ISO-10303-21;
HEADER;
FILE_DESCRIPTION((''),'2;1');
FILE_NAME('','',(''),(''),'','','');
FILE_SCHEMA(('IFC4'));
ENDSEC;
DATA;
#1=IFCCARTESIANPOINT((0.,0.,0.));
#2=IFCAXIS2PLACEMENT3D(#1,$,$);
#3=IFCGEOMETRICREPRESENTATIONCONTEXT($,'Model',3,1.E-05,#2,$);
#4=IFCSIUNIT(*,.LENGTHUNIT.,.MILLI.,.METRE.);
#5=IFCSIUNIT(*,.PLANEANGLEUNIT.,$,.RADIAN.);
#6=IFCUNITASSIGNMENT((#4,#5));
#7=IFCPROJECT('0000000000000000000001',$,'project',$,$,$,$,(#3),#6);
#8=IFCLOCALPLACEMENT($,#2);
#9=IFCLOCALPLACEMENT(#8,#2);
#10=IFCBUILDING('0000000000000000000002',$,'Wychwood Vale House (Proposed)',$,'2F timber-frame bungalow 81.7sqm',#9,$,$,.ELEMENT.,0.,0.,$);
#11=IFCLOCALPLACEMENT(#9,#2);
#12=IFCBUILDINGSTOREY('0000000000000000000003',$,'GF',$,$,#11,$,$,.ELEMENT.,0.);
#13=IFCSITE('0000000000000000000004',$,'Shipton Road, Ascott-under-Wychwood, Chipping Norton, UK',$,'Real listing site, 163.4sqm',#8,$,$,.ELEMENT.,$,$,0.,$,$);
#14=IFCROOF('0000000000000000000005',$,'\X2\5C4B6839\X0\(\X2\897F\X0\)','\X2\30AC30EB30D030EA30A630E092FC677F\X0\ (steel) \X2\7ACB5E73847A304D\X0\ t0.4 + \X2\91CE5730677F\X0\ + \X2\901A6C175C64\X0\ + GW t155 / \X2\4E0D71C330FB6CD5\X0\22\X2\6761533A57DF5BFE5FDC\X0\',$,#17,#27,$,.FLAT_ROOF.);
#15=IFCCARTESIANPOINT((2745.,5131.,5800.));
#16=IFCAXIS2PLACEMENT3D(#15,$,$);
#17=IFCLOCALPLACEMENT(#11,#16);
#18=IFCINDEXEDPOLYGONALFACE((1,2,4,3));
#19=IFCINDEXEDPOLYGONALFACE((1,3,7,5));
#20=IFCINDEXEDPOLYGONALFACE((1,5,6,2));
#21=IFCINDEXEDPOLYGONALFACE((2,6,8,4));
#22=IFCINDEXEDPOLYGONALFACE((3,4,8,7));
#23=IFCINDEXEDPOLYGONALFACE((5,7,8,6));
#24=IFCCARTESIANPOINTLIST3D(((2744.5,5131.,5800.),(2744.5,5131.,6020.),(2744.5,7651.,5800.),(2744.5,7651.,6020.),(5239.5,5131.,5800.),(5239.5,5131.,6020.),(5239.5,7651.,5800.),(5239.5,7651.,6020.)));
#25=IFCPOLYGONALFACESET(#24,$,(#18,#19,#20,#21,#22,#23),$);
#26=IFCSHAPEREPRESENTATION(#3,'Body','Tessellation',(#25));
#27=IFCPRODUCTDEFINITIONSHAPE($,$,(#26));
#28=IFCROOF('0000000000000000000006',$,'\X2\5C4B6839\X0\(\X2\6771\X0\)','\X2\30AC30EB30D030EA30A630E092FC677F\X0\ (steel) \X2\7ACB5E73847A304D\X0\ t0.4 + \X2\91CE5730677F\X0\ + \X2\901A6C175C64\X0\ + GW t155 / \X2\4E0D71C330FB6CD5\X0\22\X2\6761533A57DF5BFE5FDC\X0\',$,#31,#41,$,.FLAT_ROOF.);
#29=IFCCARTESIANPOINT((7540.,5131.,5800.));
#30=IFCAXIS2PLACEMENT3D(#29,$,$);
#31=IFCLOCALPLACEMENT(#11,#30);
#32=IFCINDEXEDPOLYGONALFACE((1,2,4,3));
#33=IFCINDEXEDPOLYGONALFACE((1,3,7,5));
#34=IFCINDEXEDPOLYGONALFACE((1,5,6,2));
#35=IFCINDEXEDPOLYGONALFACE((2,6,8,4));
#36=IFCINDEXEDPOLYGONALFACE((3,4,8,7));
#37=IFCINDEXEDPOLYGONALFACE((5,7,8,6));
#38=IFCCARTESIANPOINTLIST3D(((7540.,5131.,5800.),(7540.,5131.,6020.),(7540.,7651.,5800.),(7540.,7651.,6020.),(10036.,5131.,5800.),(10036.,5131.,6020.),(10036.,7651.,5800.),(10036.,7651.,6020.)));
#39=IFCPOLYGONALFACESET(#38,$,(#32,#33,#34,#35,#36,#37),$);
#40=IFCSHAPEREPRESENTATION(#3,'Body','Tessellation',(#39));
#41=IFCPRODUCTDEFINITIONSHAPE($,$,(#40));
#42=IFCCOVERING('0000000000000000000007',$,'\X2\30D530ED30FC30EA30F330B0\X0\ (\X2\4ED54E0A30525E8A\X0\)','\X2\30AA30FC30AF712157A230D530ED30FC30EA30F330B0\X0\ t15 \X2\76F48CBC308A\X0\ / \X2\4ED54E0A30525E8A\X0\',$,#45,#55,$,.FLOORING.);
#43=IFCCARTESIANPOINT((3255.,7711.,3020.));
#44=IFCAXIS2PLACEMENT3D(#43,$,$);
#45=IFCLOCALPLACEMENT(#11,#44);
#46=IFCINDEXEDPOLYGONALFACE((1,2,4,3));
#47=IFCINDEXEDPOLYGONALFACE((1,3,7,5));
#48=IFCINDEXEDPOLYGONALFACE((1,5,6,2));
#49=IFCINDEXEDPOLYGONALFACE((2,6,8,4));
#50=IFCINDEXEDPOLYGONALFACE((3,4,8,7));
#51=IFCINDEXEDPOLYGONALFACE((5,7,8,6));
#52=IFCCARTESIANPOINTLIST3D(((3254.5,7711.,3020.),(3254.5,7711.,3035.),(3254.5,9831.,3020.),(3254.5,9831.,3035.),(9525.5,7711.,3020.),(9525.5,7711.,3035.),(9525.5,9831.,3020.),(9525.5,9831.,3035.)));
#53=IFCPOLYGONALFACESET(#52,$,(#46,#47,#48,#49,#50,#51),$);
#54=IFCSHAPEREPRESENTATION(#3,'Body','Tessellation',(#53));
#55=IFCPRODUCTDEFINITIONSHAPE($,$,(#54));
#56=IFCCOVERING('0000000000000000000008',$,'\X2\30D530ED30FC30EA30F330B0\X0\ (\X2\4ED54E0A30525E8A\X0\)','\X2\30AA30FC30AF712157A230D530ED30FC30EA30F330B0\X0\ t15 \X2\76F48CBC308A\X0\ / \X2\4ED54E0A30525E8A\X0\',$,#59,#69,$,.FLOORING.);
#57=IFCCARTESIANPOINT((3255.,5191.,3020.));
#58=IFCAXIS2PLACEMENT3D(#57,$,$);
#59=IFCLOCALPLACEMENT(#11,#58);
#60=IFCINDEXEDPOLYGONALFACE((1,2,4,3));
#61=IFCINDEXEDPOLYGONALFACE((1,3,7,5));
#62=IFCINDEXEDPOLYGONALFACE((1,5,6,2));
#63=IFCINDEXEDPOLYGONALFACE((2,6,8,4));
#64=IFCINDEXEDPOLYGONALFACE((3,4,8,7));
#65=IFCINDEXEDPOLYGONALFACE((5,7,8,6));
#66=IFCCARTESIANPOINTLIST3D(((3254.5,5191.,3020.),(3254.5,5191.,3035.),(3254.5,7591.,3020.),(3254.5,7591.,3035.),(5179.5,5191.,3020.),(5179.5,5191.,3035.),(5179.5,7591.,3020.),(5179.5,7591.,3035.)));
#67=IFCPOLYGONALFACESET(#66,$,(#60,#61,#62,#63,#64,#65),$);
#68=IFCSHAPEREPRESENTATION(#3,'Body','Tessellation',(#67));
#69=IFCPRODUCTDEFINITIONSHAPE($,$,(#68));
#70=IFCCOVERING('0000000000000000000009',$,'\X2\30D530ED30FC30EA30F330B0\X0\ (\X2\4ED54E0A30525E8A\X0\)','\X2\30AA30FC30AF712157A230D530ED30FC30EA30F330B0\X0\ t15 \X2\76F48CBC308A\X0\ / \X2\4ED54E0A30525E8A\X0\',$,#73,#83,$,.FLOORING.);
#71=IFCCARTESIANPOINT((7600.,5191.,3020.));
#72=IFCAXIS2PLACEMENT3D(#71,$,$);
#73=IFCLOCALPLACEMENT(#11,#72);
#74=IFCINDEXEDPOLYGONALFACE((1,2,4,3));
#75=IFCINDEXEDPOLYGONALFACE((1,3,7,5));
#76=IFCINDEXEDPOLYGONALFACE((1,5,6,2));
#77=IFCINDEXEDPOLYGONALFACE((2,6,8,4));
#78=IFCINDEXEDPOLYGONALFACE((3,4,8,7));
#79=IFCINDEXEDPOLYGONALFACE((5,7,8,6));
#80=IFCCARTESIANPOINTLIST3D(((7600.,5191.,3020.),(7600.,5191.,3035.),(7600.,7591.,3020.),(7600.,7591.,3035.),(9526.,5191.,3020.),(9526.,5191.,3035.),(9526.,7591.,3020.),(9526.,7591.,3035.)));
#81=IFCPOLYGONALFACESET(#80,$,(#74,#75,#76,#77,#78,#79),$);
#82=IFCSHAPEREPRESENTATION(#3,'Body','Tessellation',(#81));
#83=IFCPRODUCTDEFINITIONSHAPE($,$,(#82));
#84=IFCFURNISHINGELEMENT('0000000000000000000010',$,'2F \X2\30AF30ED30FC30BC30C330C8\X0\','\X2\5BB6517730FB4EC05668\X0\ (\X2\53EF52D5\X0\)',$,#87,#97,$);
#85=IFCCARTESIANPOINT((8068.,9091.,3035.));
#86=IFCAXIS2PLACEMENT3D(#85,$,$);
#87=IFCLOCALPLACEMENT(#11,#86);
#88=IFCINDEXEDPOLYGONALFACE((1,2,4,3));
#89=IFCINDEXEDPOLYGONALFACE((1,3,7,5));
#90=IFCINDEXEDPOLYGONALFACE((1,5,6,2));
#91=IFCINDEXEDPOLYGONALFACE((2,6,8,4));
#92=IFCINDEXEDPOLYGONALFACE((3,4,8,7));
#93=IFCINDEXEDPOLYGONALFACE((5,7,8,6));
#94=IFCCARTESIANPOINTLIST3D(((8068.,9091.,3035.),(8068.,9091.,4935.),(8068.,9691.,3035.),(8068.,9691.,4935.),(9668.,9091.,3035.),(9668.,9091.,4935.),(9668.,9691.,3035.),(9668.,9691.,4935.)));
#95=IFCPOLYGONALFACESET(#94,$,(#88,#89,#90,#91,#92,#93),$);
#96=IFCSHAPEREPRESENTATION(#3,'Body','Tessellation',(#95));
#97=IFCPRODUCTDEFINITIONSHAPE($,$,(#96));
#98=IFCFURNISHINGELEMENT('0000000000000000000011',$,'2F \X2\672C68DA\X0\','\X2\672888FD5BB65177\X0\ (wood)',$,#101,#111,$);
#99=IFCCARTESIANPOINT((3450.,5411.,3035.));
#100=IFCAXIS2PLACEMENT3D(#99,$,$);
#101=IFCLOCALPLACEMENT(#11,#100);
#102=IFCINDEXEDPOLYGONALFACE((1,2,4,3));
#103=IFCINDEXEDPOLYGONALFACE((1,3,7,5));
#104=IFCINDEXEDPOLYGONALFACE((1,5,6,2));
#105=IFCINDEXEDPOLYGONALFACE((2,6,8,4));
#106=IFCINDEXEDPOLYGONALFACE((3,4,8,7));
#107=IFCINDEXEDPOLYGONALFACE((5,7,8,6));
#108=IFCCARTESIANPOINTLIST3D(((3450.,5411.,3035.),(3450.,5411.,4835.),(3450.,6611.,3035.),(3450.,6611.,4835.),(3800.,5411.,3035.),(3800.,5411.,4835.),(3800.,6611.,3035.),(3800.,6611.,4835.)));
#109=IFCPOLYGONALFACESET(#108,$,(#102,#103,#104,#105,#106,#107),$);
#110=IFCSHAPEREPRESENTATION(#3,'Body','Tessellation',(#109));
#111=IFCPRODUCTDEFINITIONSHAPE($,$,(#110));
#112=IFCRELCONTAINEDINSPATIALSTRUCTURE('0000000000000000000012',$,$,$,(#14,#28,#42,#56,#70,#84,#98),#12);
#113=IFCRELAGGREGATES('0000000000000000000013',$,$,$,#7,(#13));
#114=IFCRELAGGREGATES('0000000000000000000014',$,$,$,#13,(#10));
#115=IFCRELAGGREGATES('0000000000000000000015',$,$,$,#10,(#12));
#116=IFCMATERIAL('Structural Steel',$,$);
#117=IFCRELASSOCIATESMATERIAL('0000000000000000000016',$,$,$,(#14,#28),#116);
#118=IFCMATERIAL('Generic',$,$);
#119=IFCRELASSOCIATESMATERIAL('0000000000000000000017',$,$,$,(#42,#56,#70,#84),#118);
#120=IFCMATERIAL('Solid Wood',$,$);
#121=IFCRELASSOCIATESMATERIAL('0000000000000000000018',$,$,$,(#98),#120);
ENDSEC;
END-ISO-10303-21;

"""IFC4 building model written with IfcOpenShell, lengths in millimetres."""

from ifc_helpers import new_model, si_unit, frame, frame_2d, origin, place, context, project, spatial, rectangle, extrude, material, element, save


model = new_model("IFC4")

# Units and contexts
model_context = context("Model", 3, precision=1e-05, world=origin())
ifc_project = project(units=[si_unit("LENGTHUNIT", "METRE", prefix="MILLI"), si_unit("PLANEANGLEUNIT", "RADIAN")], contexts=[model_context])

# Site, building, storey
site_placement = place(None, origin())
site = spatial("IfcSite", under=ifc_project, at=site_placement, Name="Shipton Road, Ascott-under-Wychwood, Chipping Norton, UK", ObjectType="Real listing site, 163.4sqm", CompositionType="ELEMENT", RefElevation=0.0)
building_placement = place(site_placement, origin())
building = spatial("IfcBuilding", under=site, at=building_placement, Name="Wychwood Vale House (Proposed)", ObjectType="2F timber-frame bungalow 81.7sqm", CompositionType="ELEMENT", ElevationOfRefHeight=0.0, ElevationOfTerrain=0.0)
storey_placement = place(building_placement, origin())
storey = spatial("IfcBuildingStorey", under=building, at=storey_placement, Name="GF", CompositionType="ELEMENT", Elevation=0.0)

# Shared definitions
ifc_material_1 = material(Name="Solid Wood")

# Roofs
ifc_material_2 = material(Name="Structural Steel")
roof_1_placement = place(storey_placement, frame((2745.0, 5131.0, 5800.0)))
element("IfcRoof", 1, at=roof_1_placement, inside=storey, material=ifc_material_2, Name="屋根(西)", Description="ガルバリウム鋼板 (steel) 立平葺き t0.4 + 野地板 + 通気層 + GW t155 / 不燃・法22条区域対応", PredefinedType="FLAT_ROOF", context=model_context, shape_type="SweptSolid", body=[
    extrude(rectangle(XDim=2495.0, YDim=2520.0, at=frame_2d((1247.0, 1260.0))), frame((2745.0, 5131.0, 5800.0)), (0.0, 0.0, 1.0), 220.0),
])
roof_2_placement = place(storey_placement, frame((7540.0, 5131.0, 5800.0)))
element("IfcRoof", 2, at=roof_2_placement, inside=storey, material=ifc_material_2, Name="屋根(東)", Description="ガルバリウム鋼板 (steel) 立平葺き t0.4 + 野地板 + 通気層 + GW t155 / 不燃・法22条区域対応", PredefinedType="FLAT_ROOF", context=model_context, shape_type="SweptSolid", body=[
    extrude(rectangle(XDim=2496.0, YDim=2520.0, at=frame_2d((1248.0, 1260.0))), frame((7540.0, 5131.0, 5800.0)), (0.0, 0.0, 1.0), 220.0),
])

# Coverings
ifc_material_3 = material(Name="Generic")
covering_1_placement = place(storey_placement, frame((3255.0, 7711.0, 3020.0)))
element("IfcCovering", 3, at=covering_1_placement, inside=storey, material=ifc_material_3, Name="フローリング (仕上げ床)", Description="オーク無垢フローリング t15 直貼り / 仕上げ床", PredefinedType="FLOORING", context=model_context, shape_type="SweptSolid", body=[
    extrude(rectangle(XDim=6271.0, YDim=2120.0, at=frame_2d((3135.0, 1060.0))), frame((3255.0, 7711.0, 3020.0)), (0.0, 0.0, 1.0), 15.0),
])
covering_2_placement = place(storey_placement, frame((3255.0, 5191.0, 3020.0)))
element("IfcCovering", 4, at=covering_2_placement, inside=storey, material=ifc_material_3, Name="フローリング (仕上げ床)", Description="オーク無垢フローリング t15 直貼り / 仕上げ床", PredefinedType="FLOORING", context=model_context, shape_type="SweptSolid", body=[
    extrude(rectangle(XDim=1925.0, YDim=2400.0, at=frame_2d((962.0, 1200.0))), frame((3255.0, 5191.0, 3020.0)), (0.0, 0.0, 1.0), 15.0),
])
covering_3_placement = place(storey_placement, frame((7600.0, 5191.0, 3020.0)))
element("IfcCovering", 5, at=covering_3_placement, inside=storey, material=ifc_material_3, Name="フローリング (仕上げ床)", Description="オーク無垢フローリング t15 直貼り / 仕上げ床", PredefinedType="FLOORING", context=model_context, shape_type="SweptSolid", body=[
    extrude(rectangle(XDim=1926.0, YDim=2400.0, at=frame_2d((963.0, 1200.0))), frame((7600.0, 5191.0, 3020.0)), (0.0, 0.0, 1.0), 15.0),
])

# Furnishing elements
furnishing_1_placement = place(storey_placement, frame((8068.0, 9091.0, 3035.0)))
element("IfcFurnishingElement", 6, at=furnishing_1_placement, inside=storey, material=ifc_material_3, Name="2F クローゼット", Description="家具・什器 (可動)", context=model_context, shape_type="SweptSolid", body=[
    extrude(rectangle(XDim=1600.0, YDim=600.0, at=frame_2d((800.0, 300.0))), frame((8068.0, 9091.0, 3035.0)), (0.0, 0.0, 1.0), 1900.0),
])
furnishing_2_placement = place(storey_placement, frame((3450.0, 5411.0, 3035.0)))
element("IfcFurnishingElement", 7, at=furnishing_2_placement, inside=storey, material=ifc_material_1, Name="2F 本棚", Description="木製家具 (wood)", context=model_context, shape_type="SweptSolid", body=[
    extrude(rectangle(XDim=350.0, YDim=1200.0, at=frame_2d((175.0, 600.0))), frame((3450.0, 5411.0, 3035.0)), (0.0, 0.0, 1.0), 1800.0),
])

save(model, "model.ifc")
